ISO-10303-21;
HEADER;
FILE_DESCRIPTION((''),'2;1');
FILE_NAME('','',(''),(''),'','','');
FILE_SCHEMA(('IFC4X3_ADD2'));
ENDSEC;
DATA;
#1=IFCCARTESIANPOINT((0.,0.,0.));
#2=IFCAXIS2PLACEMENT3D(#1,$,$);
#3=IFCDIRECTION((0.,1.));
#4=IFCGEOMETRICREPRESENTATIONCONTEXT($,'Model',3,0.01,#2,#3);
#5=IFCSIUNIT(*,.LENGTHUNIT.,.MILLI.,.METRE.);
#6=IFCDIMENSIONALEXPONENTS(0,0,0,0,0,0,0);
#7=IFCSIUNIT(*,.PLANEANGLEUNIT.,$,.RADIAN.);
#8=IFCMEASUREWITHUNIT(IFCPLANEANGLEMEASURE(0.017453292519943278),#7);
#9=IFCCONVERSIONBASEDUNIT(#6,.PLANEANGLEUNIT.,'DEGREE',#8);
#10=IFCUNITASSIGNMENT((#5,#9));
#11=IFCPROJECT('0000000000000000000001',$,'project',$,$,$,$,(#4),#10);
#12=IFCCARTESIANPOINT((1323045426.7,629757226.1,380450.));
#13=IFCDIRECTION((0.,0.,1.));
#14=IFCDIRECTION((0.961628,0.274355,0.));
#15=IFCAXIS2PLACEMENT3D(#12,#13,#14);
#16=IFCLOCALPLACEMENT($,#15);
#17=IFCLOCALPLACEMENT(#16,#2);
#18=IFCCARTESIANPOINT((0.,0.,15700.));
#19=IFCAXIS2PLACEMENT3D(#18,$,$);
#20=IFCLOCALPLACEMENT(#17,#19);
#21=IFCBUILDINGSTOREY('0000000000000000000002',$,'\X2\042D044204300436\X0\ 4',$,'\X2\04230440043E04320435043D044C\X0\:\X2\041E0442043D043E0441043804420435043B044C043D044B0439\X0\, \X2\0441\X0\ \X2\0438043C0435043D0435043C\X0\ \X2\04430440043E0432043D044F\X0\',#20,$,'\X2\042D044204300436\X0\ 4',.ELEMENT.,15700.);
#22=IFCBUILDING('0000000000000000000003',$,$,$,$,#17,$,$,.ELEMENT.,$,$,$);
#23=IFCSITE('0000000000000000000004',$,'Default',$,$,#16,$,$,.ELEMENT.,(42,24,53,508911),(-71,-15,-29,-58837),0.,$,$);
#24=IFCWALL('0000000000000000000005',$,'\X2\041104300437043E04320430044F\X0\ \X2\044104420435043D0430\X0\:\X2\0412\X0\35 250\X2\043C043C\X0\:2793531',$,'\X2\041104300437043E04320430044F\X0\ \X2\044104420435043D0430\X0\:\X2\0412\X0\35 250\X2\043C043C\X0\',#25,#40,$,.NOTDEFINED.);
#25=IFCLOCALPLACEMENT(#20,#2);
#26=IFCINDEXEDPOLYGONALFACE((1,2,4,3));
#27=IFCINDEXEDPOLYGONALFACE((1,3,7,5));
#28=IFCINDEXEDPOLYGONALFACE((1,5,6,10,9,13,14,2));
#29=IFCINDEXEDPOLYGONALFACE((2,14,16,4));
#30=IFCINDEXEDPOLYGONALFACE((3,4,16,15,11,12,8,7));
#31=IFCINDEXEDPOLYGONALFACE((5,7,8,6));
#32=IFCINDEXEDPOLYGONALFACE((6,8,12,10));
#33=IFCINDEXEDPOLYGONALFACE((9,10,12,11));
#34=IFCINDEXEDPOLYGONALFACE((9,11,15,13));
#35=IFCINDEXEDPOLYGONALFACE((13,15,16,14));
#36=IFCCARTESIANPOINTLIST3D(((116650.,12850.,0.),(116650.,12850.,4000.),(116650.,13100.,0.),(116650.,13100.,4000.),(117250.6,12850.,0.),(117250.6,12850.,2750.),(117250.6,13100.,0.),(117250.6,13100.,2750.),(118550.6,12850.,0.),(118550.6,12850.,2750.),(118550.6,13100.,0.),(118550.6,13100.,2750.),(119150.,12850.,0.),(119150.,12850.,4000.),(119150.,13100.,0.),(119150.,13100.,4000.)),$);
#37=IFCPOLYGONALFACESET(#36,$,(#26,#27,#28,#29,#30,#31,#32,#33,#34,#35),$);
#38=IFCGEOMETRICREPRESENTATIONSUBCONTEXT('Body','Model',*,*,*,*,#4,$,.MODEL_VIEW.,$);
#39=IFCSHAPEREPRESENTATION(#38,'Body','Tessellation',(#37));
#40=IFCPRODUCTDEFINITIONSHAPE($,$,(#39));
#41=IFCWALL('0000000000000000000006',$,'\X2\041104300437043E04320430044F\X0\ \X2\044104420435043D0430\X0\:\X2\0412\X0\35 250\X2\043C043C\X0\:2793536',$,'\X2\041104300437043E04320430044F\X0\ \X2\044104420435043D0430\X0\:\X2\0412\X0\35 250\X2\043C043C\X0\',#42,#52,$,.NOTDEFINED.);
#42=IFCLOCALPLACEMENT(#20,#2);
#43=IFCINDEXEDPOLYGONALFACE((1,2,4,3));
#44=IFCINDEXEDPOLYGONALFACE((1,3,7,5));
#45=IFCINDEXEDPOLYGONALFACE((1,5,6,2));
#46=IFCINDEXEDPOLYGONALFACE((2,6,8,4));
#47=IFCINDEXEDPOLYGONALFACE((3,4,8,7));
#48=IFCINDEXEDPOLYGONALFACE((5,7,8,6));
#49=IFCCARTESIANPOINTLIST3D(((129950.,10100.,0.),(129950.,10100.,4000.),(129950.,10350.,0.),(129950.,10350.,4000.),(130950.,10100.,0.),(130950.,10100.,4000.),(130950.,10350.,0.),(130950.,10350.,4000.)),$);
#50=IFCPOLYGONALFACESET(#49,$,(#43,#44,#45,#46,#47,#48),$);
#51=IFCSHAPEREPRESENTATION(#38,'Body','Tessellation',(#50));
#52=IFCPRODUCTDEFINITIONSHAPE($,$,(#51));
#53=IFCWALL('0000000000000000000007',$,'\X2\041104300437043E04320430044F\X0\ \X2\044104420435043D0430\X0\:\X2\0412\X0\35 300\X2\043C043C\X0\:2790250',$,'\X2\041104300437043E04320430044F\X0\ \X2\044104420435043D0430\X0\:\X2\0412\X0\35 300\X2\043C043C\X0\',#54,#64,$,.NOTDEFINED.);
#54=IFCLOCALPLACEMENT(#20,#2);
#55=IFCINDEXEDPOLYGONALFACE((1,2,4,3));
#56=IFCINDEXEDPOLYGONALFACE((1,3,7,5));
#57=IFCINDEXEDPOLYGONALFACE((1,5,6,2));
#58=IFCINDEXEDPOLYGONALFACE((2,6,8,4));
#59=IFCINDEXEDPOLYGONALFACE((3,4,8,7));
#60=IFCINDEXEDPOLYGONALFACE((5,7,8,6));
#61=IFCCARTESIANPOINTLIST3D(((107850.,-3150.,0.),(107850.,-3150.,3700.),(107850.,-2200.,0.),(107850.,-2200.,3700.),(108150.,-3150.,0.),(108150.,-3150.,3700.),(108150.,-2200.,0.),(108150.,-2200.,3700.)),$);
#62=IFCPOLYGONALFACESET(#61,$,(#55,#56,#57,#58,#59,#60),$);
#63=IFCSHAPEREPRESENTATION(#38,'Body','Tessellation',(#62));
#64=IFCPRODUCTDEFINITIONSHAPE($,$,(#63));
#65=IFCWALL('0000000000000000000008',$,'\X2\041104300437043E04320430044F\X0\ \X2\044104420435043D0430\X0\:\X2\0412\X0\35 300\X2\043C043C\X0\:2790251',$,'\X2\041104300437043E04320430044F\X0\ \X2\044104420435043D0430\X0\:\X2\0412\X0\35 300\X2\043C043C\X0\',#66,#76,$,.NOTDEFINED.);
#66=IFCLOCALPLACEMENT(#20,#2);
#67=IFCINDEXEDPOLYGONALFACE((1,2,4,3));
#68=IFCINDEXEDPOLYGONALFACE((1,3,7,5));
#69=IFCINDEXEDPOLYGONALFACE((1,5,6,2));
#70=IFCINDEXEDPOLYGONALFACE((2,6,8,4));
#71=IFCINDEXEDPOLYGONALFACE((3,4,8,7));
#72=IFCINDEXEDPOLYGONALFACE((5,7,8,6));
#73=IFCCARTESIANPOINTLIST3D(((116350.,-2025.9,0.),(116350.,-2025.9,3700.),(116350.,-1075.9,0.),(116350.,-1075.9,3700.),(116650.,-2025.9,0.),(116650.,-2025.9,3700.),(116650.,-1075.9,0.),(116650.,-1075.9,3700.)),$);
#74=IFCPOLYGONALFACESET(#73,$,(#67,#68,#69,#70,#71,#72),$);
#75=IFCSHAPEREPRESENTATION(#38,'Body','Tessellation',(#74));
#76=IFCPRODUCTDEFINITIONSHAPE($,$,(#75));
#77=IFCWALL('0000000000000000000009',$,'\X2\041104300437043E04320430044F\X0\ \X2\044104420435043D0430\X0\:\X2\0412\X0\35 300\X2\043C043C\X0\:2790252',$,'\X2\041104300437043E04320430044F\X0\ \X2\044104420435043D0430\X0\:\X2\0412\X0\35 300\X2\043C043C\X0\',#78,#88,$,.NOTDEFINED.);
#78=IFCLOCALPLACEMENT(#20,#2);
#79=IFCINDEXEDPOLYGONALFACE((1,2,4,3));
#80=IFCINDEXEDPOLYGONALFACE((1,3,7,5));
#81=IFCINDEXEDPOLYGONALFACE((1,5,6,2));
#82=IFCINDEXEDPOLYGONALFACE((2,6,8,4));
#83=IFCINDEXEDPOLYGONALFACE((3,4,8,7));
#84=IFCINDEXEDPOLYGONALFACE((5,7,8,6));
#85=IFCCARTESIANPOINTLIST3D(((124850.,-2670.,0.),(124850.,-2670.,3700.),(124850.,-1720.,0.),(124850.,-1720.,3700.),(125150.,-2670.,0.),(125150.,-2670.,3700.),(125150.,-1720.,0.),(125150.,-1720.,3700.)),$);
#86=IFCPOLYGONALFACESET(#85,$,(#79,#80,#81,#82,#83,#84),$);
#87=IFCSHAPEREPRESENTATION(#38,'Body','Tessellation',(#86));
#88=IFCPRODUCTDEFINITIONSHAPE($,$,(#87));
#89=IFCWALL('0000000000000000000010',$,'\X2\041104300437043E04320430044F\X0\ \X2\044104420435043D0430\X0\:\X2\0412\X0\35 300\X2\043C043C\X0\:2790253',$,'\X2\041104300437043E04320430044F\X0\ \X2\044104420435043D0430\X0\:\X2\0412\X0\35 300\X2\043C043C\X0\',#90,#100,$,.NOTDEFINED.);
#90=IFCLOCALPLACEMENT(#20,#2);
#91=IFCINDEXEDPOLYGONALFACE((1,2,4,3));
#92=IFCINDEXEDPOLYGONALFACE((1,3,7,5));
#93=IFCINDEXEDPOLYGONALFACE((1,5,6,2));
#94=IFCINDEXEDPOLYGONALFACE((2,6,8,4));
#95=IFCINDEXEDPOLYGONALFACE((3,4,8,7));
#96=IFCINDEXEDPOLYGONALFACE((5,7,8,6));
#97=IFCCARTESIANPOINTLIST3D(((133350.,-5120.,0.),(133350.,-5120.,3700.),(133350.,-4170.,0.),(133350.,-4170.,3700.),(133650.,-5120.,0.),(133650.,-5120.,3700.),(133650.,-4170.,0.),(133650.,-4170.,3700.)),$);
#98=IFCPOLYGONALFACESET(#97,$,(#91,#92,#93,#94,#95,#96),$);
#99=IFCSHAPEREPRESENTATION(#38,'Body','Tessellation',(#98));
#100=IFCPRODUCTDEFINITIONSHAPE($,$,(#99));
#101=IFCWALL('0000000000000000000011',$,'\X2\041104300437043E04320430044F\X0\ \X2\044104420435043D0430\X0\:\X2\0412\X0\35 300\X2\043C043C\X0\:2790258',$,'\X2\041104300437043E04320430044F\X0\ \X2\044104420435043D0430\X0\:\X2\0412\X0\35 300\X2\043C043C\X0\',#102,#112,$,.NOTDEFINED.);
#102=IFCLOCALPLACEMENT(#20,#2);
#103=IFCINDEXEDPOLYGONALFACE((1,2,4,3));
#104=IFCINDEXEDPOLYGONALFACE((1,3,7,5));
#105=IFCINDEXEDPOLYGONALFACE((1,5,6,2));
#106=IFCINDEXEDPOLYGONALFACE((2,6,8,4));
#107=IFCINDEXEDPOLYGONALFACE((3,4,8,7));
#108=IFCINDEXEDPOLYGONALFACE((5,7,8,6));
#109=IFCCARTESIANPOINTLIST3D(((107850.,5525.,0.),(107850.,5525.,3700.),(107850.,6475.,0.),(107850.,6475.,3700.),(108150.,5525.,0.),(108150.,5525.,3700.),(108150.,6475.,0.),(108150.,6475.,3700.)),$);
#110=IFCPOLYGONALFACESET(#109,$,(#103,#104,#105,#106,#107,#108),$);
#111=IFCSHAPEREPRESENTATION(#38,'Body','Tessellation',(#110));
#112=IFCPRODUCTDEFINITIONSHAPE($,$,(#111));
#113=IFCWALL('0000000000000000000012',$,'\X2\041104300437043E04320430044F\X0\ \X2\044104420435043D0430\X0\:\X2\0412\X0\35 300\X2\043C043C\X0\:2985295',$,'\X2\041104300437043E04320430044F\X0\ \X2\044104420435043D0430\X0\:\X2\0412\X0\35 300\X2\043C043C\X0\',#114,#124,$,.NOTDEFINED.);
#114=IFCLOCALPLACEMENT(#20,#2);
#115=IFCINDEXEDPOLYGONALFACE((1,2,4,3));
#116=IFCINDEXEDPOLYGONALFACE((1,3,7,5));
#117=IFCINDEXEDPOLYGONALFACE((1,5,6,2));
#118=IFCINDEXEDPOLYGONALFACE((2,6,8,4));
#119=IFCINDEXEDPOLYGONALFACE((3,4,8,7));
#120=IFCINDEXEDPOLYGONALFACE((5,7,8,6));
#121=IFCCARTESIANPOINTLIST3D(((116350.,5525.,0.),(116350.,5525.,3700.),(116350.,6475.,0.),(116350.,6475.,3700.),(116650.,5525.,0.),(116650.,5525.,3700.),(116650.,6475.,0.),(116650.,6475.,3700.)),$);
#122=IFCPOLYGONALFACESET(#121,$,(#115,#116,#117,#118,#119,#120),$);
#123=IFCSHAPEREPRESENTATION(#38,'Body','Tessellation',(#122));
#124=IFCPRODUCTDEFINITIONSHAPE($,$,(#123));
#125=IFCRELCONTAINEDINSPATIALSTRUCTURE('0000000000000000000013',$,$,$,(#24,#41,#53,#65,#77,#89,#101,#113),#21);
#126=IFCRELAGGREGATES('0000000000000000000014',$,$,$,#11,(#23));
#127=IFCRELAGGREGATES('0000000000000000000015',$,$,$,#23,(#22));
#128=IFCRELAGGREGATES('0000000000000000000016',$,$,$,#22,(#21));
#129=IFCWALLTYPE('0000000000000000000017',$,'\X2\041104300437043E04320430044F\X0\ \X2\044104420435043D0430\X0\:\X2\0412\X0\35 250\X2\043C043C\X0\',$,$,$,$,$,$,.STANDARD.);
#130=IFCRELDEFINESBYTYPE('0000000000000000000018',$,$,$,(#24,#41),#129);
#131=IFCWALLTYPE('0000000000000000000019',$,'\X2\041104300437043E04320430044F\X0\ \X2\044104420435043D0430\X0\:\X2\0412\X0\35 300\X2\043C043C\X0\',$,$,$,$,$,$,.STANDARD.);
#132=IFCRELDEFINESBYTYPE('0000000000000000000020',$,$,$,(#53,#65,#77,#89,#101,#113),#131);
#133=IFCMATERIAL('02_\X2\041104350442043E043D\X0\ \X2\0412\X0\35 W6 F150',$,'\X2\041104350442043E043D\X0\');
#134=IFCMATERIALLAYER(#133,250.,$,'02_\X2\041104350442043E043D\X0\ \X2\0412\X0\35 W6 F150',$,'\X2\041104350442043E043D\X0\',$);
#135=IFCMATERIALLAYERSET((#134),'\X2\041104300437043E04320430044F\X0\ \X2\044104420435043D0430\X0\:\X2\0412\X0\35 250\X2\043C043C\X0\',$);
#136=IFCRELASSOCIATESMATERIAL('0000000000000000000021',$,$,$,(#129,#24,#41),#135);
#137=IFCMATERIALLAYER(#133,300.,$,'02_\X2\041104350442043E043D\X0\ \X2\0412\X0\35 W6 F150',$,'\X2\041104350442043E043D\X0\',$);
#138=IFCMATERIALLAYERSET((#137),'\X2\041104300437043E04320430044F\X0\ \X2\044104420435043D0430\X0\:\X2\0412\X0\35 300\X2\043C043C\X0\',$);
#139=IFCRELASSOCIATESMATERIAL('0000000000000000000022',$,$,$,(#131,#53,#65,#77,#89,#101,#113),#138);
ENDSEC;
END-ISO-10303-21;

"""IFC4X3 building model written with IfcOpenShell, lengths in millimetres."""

from ifc_helpers import new_model, entity, si_unit, converted_unit, direction, frame, frame_2d, origin, place, context, subcontext, project, spatial, rectangle, extrude, material, layer, layer_set, type_object, element, save


model = new_model("IFC4X3")

# Units and contexts
model_context = context("Model", 3, precision=0.01, world=origin(), true_north=direction((0.0, 1.0)))
body_context = subcontext(model_context, "Body", "Model", "MODEL_VIEW")
ifc_project = project(units=[si_unit("LENGTHUNIT", "METRE", prefix="MILLI"), converted_unit("PLANEANGLEUNIT", "DEGREE", entity("IfcPlaneAngleMeasure", 0.017453292519943278), si_unit("PLANEANGLEUNIT", "RADIAN"), dimensions=[0, 0, 0, 0, 0, 0, 0])], contexts=[model_context])

# Site, building, storey
site_placement = place(None, frame((1323045426.7, 629757226.1, 380450.0), z_axis=(0.0, 0.0, 1.0), x_axis=(0.961628, 0.274355, 0.0)))
site = spatial("IfcSite", under=ifc_project, at=site_placement, Name="Default", CompositionType="ELEMENT", RefLatitude=(42, 24, 53, 508911), RefLongitude=(-71, -15, -29, -58837), RefElevation=0.0)
building_placement = place(site_placement, origin())
building = spatial("IfcBuilding", under=site, at=building_placement, CompositionType="ELEMENT")
storey_placement = place(building_placement, frame((0.0, 0.0, 15700.0)))
storey = spatial("IfcBuildingStorey", under=building, at=storey_placement, Name="Этаж 4", ObjectType="Уровень:Относительный, с именем уровня", LongName="Этаж 4", CompositionType="ELEMENT", Elevation=15700.0)

# Shared definitions
ifc_material = material(Name="02_Бетон В35 W6 F150", Category="Бетон")
ifc_layer_1 = layer(ifc_material, 250.0, Name="02_Бетон В35 W6 F150", Category="Бетон")
ifc_layer_set_1 = layer_set([ifc_layer_1], Name="Базовая стена:В35 250мм")
wall_type_1 = type_object("IfcWallType", Name="Базовая стена:В35 250мм", PredefinedType="STANDARD", material=ifc_layer_set_1)

# Wall, opening
wall_1_placement = place(storey_placement, frame((116650.0, 12975.0, 0.0)))
wall_1 = element("IfcWall", 1, at=wall_1_placement, inside=storey, type_object=wall_type_1, material=ifc_layer_set_1, Name="Базовая стена:В35 250мм:2793531", ObjectType="Базовая стена:В35 250мм", PredefinedType="NOTDEFINED", context=body_context, shape_type="SweptSolid", body=[
    extrude(rectangle(XDim=2500.0, YDim=250.0, at=frame_2d((1250.0, 0.0), x_axis=(1.0, 0.0))), origin(), (0.0, 0.0, 1.0), 4000.0),
])
opening_1_placement = place(wall_1_placement, frame((-116650.0, -12975.0, 0.0)))
element("IfcOpeningElement", 2, at=opening_1_placement, cuts=wall_1, PredefinedType="OPENING", context=body_context, shape_type="SweptSolid", body=[
    extrude(rectangle(XDim=2750.0, YDim=1300.0, at=frame_2d((0.0, 0.0), x_axis=(1.0, 0.0))), frame((117900.6, 11326.0, 1375.0), z_axis=(0.0, 1.0, 0.0), x_axis=(0.0, 0.0, -1.0)), (0.0, 0.0, 1.0), 3048.0),
])

# Walls
wall_2_placement = place(storey_placement, frame((129950.0, 10225.0, 0.0)))
element("IfcWall", 3, at=wall_2_placement, inside=storey, type_object=wall_type_1, material=ifc_layer_set_1, Name="Базовая стена:В35 250мм:2793536", ObjectType="Базовая стена:В35 250мм", PredefinedType="NOTDEFINED", context=body_context, shape_type="SweptSolid", body=[
    extrude(rectangle(XDim=1000.0, YDim=250.0, at=frame_2d((500.0, 0.0), x_axis=(-1.0, 0.0))), origin(), (0.0, 0.0, 1.0), 4000.0),
])
ifc_layer_2 = layer(ifc_material, 300.0, Name="02_Бетон В35 W6 F150", Category="Бетон")
ifc_layer_set_2 = layer_set([ifc_layer_2], Name="Базовая стена:В35 300мм")
wall_type_2 = type_object("IfcWallType", Name="Базовая стена:В35 300мм", PredefinedType="STANDARD", material=ifc_layer_set_2)
for number, where, z_axis, x_axis, name in (
    (4, (108000.0, -3150.0, 0.0), (0.0, 0.0, 1.0), (0.0, 1.0, 0.0), "Базовая стена:В35 300мм:2790250"),
    (5, (116500.0, -2025.9, 0.0), (0.0, 0.0, 1.0), (0.0, 1.0, 0.0), "Базовая стена:В35 300мм:2790251"),
    (6, (125000.0, -2670.0, 0.0), (0.0, 0.0, 1.0), (0.0, 1.0, 0.0), "Базовая стена:В35 300мм:2790252"),
    (7, (133500.0, -5120.0, 0.0), (0.0, 0.0, 1.0), (0.0, 1.0, 0.0), "Базовая стена:В35 300мм:2790253"),
    (8, (108000.0, 5525.0, 0.0), (0.0, 0.0, 1.0), (0.0, 1.0, 0.0), "Базовая стена:В35 300мм:2790258"),
    (9, (116500.0, 5525.0, 0.0), (0.0, 0.0, 1.0), (0.0, 1.0, 0.0), "Базовая стена:В35 300мм:2985295"),
):
    element("IfcWall", number, at=place(storey_placement, frame(where, z_axis=z_axis, x_axis=x_axis)), inside=storey, type_object=wall_type_2, material=ifc_layer_set_2, Name=name, ObjectType="Базовая стена:В35 300мм", PredefinedType="NOTDEFINED", context=body_context, shape_type="SweptSolid", body=[
        extrude(rectangle(XDim=950.0, YDim=300.0, at=frame_2d((475.0, 0.0), x_axis=(-1.0, 0.0))), origin(), (0.0, 0.0, 1.0), 3700.0),
    ])

save(model, "model.ifc")
